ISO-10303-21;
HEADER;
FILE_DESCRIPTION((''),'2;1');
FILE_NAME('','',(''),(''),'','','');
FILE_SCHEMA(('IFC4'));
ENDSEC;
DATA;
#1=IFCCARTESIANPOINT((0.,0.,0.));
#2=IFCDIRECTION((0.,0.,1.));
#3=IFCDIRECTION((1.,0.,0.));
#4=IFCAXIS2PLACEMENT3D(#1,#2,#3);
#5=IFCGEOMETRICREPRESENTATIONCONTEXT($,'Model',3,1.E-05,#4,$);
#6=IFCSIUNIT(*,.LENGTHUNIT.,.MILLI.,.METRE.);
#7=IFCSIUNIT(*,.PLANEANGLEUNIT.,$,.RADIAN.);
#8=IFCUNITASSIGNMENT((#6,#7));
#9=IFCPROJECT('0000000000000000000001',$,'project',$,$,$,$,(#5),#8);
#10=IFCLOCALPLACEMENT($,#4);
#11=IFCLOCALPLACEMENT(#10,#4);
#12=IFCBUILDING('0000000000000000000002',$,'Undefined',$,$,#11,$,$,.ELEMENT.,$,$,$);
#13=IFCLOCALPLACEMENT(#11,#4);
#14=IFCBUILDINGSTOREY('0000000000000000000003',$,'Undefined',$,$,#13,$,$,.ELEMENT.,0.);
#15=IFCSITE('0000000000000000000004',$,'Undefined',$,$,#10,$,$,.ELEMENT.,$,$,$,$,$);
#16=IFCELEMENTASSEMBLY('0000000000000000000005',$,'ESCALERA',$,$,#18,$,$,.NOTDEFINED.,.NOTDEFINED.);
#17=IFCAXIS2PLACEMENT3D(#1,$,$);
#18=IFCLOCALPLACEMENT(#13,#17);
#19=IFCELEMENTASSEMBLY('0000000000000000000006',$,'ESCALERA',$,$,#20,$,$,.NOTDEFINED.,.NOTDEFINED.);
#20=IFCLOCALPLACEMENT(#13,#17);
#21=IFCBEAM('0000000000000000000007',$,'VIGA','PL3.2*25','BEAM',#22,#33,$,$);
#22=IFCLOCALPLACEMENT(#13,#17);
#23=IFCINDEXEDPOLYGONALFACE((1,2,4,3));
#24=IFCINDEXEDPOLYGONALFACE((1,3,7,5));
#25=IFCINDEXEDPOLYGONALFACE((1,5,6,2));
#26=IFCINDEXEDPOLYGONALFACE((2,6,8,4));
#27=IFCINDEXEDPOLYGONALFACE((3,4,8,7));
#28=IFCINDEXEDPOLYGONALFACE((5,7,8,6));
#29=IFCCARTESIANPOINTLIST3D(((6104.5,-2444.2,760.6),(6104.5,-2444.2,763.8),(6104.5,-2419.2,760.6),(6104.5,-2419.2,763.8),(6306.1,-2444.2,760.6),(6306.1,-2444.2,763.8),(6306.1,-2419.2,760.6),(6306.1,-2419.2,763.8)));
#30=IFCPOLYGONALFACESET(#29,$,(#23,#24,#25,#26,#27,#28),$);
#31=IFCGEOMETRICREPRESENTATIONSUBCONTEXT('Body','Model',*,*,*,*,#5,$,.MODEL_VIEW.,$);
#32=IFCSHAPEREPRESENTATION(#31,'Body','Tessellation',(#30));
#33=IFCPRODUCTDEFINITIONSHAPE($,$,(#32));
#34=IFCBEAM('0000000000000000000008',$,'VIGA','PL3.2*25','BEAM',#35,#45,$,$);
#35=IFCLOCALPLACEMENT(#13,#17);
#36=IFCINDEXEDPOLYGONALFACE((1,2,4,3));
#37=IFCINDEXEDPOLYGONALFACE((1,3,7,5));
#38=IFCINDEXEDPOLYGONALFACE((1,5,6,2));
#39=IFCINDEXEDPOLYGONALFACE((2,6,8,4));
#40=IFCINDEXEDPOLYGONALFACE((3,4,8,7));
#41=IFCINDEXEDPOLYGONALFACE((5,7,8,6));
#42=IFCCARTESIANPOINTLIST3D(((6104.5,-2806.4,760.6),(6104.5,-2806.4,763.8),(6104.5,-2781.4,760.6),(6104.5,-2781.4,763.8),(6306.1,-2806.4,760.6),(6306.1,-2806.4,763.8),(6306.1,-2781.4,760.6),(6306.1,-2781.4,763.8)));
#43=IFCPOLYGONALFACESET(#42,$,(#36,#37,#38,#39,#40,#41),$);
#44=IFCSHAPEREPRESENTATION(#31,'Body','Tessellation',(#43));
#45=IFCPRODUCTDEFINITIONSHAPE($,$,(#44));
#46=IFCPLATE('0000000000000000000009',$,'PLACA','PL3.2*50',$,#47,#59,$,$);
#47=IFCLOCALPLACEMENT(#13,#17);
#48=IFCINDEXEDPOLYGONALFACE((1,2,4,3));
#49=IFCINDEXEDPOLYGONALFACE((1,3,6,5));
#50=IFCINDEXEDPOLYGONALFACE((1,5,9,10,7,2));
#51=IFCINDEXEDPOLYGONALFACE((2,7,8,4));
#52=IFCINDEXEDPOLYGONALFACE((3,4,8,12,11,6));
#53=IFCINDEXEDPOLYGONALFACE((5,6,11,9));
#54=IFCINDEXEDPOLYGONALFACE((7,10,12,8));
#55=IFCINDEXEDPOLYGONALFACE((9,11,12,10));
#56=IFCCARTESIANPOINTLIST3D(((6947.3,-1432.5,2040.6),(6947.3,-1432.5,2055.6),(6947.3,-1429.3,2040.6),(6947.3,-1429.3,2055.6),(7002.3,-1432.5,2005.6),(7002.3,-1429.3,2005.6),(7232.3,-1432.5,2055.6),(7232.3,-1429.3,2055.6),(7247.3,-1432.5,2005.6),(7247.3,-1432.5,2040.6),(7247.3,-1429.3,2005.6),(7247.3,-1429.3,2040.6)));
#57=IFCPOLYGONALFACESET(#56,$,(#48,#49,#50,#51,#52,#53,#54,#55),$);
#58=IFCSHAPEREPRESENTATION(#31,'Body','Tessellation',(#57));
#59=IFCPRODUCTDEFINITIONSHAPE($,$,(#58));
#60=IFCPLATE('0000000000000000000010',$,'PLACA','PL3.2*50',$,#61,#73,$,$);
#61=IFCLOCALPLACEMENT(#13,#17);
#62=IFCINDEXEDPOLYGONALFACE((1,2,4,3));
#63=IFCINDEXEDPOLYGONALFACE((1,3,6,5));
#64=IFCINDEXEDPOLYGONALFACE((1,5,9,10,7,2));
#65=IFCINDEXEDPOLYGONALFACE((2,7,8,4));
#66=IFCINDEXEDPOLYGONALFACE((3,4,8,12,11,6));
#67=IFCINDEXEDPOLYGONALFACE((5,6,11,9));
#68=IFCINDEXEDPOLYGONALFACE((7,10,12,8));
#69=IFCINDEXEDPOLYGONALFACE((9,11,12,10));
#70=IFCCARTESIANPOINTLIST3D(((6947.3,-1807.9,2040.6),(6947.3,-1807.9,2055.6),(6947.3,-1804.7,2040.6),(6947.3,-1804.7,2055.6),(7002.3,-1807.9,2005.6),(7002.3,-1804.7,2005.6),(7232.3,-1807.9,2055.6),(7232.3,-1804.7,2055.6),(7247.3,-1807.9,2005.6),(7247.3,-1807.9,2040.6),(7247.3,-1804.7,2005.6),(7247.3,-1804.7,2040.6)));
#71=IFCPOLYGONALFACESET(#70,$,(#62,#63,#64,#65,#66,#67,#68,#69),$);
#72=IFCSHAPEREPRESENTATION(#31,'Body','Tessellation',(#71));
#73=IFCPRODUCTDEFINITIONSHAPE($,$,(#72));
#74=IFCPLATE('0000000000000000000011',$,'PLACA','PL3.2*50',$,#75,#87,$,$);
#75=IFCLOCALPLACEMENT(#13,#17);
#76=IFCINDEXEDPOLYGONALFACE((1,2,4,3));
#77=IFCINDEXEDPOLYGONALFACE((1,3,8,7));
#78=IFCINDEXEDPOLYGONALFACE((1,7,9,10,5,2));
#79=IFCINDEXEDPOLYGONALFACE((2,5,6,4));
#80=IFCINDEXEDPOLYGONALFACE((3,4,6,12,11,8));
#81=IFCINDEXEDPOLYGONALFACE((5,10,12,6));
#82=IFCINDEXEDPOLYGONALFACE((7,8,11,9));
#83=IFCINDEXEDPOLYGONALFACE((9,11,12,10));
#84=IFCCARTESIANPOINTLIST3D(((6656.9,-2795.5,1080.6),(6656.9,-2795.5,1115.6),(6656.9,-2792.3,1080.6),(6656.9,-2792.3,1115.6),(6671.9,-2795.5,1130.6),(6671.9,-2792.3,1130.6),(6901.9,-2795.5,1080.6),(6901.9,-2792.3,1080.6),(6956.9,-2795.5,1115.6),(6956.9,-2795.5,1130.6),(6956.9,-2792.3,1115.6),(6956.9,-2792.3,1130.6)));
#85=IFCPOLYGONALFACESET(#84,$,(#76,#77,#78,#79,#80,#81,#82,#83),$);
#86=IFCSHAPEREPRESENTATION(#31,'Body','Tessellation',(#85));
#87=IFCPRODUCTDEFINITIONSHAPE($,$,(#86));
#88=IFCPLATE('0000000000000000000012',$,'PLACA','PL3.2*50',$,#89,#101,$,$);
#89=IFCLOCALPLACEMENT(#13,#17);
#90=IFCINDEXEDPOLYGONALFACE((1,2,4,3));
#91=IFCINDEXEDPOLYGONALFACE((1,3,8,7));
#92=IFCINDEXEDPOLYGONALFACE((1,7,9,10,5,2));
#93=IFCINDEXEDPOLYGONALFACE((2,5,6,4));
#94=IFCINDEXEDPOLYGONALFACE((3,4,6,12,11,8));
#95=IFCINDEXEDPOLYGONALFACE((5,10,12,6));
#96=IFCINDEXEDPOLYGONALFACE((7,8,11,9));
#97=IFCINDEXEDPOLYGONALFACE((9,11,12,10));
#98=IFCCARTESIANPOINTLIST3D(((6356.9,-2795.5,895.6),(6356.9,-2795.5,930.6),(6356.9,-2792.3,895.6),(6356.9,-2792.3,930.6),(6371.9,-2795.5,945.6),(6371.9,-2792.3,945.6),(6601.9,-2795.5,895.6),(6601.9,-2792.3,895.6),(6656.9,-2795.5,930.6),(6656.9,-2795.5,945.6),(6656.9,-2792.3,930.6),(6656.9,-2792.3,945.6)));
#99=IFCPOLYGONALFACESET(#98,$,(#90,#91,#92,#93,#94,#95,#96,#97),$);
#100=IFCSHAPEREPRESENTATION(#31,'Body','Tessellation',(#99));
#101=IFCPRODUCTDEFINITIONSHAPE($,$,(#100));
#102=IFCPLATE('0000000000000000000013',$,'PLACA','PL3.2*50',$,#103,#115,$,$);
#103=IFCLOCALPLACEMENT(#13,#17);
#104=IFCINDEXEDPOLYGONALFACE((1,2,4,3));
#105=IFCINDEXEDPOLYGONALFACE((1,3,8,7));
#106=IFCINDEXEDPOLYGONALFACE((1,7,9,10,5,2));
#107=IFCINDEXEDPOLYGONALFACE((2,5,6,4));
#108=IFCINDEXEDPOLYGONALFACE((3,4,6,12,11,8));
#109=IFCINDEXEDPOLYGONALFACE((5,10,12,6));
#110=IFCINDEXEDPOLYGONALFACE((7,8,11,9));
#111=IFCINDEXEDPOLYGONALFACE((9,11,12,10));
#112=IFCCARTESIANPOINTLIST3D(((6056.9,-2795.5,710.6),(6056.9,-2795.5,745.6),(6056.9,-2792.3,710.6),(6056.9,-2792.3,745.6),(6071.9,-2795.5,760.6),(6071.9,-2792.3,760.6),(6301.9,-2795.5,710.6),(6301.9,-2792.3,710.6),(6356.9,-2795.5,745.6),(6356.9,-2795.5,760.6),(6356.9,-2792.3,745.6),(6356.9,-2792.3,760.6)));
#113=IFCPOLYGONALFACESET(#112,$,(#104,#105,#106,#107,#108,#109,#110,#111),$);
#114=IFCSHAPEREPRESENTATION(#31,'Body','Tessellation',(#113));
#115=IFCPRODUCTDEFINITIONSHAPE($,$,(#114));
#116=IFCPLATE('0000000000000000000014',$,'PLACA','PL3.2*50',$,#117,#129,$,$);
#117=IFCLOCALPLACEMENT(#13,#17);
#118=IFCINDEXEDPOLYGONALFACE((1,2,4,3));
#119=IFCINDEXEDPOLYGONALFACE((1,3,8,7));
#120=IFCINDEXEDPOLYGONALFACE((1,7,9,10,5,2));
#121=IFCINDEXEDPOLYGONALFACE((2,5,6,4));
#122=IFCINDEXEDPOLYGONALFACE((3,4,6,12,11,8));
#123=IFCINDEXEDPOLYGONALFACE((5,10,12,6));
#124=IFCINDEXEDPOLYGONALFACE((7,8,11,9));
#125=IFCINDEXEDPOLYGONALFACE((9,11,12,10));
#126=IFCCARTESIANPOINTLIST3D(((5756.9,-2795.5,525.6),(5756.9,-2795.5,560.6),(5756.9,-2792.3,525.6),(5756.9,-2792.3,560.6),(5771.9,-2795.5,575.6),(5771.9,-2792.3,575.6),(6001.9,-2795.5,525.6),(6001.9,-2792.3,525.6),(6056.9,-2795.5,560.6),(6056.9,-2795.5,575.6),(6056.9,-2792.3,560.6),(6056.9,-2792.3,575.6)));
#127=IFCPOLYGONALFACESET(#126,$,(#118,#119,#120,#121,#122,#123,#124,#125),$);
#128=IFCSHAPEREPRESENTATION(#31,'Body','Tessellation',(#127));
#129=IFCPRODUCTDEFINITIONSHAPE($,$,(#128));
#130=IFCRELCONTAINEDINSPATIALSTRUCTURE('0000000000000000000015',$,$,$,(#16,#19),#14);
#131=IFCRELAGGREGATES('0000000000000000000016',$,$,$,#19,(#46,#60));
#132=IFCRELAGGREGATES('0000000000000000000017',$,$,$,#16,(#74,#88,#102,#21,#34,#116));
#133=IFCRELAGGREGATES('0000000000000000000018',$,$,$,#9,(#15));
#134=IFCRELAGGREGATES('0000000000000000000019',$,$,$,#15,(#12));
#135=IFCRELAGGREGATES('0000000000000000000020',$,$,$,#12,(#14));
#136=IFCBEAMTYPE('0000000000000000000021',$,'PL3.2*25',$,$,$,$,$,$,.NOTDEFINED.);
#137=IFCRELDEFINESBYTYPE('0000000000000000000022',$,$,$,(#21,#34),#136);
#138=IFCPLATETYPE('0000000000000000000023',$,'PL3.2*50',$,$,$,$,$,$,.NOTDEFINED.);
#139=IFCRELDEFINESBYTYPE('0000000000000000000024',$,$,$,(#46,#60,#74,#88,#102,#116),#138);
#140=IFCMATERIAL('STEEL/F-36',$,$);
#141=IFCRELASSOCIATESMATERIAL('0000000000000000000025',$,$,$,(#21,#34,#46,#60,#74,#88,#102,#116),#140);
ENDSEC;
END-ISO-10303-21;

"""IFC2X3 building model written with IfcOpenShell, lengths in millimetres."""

from ifc_helpers import new_model, si_unit, frame, origin_with_axes, origin_2d_with_axis, place, context, subcontext, project, spatial, polyline, rectangle, outline, extrude, material, type_object, element, aggregate, save


model = new_model("IFC2X3")

# Units and contexts
model_context = context("Model", 3, precision=1e-05, world=origin_with_axes())
body_context = subcontext(model_context, "Body", "Model", "MODEL_VIEW")
ifc_project = project(units=[si_unit("LENGTHUNIT", "METRE", prefix="MILLI"), si_unit("PLANEANGLEUNIT", "RADIAN")], contexts=[model_context])

# Site, building, storey
site_placement = place(None, origin_with_axes())
site = spatial("IfcSite", under=ifc_project, at=site_placement, Name="Undefined", CompositionType="ELEMENT")
building_placement = place(site_placement, origin_with_axes())
building = spatial("IfcBuilding", under=site, at=building_placement, Name="Undefined", CompositionType="ELEMENT")
storey_placement = place(building_placement, origin_with_axes())
storey = spatial("IfcBuildingStorey", under=building, at=storey_placement, Name="Undefined", CompositionType="ELEMENT", Elevation=0.0)

# Element assembly
assembly_1_placement = place(storey_placement, origin_with_axes())
assembly_1 = element("IfcElementAssembly", 1, at=assembly_1_placement, inside=storey, Name="ESCALERA", AssemblyPlace="NOTDEFINED", PredefinedType="NOTDEFINED")
ifc_material_1 = material(Name="STEEL/F-36")

# Element assembly
assembly_2_placement = place(storey_placement, origin_with_axes())
assembly_2 = element("IfcElementAssembly", 2, at=assembly_2_placement, inside=storey, Name="ESCALERA", AssemblyPlace="NOTDEFINED", PredefinedType="NOTDEFINED")
beam_type_1 = type_object("IfcBeamType", Name="PL3.2*25", PredefinedType="NOTDEFINED")

# Beams
beam_1_placement = place(assembly_1_placement, frame((6104.5, -2431.7, 762.2), z_axis=(0.0, 1.0, 0.0), x_axis=(1.0, 0.0, 0.000012)))
beam_1 = element("IfcBeam", 3, at=beam_1_placement, type_object=beam_type_1, material=ifc_material_1, Name="VIGA", Description="PL3.2*25", ObjectType="BEAM", context=body_context, shape_type="SweptSolid", body=[
    extrude(rectangle(XDim=3.2, YDim=25.0, at=origin_2d_with_axis()), frame((201.6, 0.0, 0.0), z_axis=(-1.0, 0.0, 0.0), x_axis=(0.0, -1.0, 0.0)), (0.0, 0.0, 1.0), 201.6),
])
beam_2_placement = place(assembly_1_placement, frame((6104.5, -2793.9, 762.2), z_axis=(0.0, 1.0, 0.0), x_axis=(1.0, 0.0, 0.000012)))
beam_2 = element("IfcBeam", 4, at=beam_2_placement, type_object=beam_type_1, material=ifc_material_1, Name="VIGA", Description="PL3.2*25", ObjectType="BEAM", context=body_context, shape_type="SweptSolid", body=[
    extrude(rectangle(XDim=3.2, YDim=25.0, at=origin_2d_with_axis()), frame((201.6, 0.0, 0.0), z_axis=(-1.0, 0.0, 0.0), x_axis=(0.0, -1.0, 0.0)), (0.0, 0.0, 1.0), 201.6),
])

# Plates
plate_type = type_object("IfcPlateType", Name="PL3.2*50", PredefinedType="NOTDEFINED")
plate_1_placement = place(assembly_2_placement, frame((6947.3, -1430.9, 2055.6), z_axis=(0.0, -1.0, 0.0), x_axis=(0.0, 0.0, -1.0)))
plate_1 = element("IfcPlate", 5, at=plate_1_placement, type_object=plate_type, material=ifc_material_1, Name="PLACA", Description="PL3.2*50", context=body_context, shape_type="SweptSolid", body=[
    extrude(outline(polyline([(0.0, 0.0), (15.0, 0.0), (50.0, 55.0), (50.0, 300.0), (50.0, 300.0), (15.0, 300.0), (0.0, 285.0), (0.0, 0.0)])), frame((0.0, 0.0, -1.6), z_axis=(0.0, 0.0, 1.0), x_axis=(1.0, 0.0, 0.0)), (0.0, 0.0, 1.0), 3.2),
])
plate_2_placement = place(assembly_2_placement, frame((6947.3, -1806.3, 2055.6), z_axis=(0.0, -1.0, 0.0), x_axis=(0.0, 0.0, -1.0)))
plate_2 = element("IfcPlate", 6, at=plate_2_placement, type_object=plate_type, material=ifc_material_1, Name="PLACA", Description="PL3.2*50", context=body_context, shape_type="SweptSolid", body=[
    extrude(outline(polyline([(0.0, 0.0), (15.0, 0.0), (50.0, 55.0), (50.0, 300.0), (50.0, 300.0), (15.0, 300.0), (0.0, 285.0), (0.0, 0.0)])), frame((0.0, 0.0, -1.6), z_axis=(0.0, 0.0, 1.0), x_axis=(1.0, 0.0, 0.0)), (0.0, 0.0, 1.0), 3.2),
])
aggregate(assembly_2, [plate_1, plate_2])
plate_3_placement = place(assembly_1_placement, frame((6956.9, -2793.9, 1130.6), z_axis=(0.0, 1.0, 0.0), x_axis=(0.0, 0.0, -1.0)))
plate_3 = element("IfcPlate", 7, at=plate_3_placement, type_object=plate_type, material=ifc_material_1, Name="PLACA", Description="PL3.2*50", context=body_context, shape_type="SweptSolid", body=[
    extrude(outline(polyline([(0.0, 0.0), (15.0, 0.0), (50.0, 55.0), (50.0, 300.0), (50.0, 300.0), (15.0, 300.0), (0.0, 285.0), (0.0, 0.0)])), frame((0.0, 0.0, -1.6), z_axis=(0.0, 0.0, 1.0), x_axis=(1.0, 0.0, 0.0)), (0.0, 0.0, 1.0), 3.2),
])
plate_4_placement = place(assembly_1_placement, frame((6656.9, -2793.9, 945.6), z_axis=(0.0, 1.0, 0.0), x_axis=(0.0, 0.0, -1.0)))
plate_4 = element("IfcPlate", 8, at=plate_4_placement, type_object=plate_type, material=ifc_material_1, Name="PLACA", Description="PL3.2*50", context=body_context, shape_type="SweptSolid", body=[
    extrude(outline(polyline([(0.0, 0.0), (15.0, 0.0), (50.0, 55.0), (50.0, 300.0), (50.0, 300.0), (15.0, 300.0), (0.0, 285.0), (0.0, 0.0)])), frame((0.0, 0.0, -1.6), z_axis=(0.0, 0.0, 1.0), x_axis=(1.0, 0.0, 0.0)), (0.0, 0.0, 1.0), 3.2),
])
plate_5_placement = place(assembly_1_placement, frame((6356.9, -2793.9, 760.6), z_axis=(0.0, 1.0, 0.0), x_axis=(0.0, 0.0, -1.0)))
plate_5 = element("IfcPlate", 9, at=plate_5_placement, type_object=plate_type, material=ifc_material_1, Name="PLACA", Description="PL3.2*50", context=body_context, shape_type="SweptSolid", body=[
    extrude(outline(polyline([(0.0, 0.0), (15.0, 0.0), (50.0, 55.0), (50.0, 300.0), (50.0, 300.0), (15.0, 300.0), (0.0, 285.0), (0.0, 0.0)])), frame((0.0, 0.0, -1.6), z_axis=(0.0, 0.0, 1.0), x_axis=(1.0, 0.0, 0.0)), (0.0, 0.0, 1.0), 3.2),
])
plate_6_placement = place(assembly_1_placement, frame((6056.9, -2793.9, 575.6), z_axis=(0.0, 1.0, 0.0), x_axis=(0.0, 0.0, -1.0)))
plate_6 = element("IfcPlate", 10, at=plate_6_placement, type_object=plate_type, material=ifc_material_1, Name="PLACA", Description="PL3.2*50", context=body_context, shape_type="SweptSolid", body=[
    extrude(outline(polyline([(0.0, 0.0), (15.0, 0.0), (50.0, 55.0), (50.0, 300.0), (50.0, 300.0), (15.0, 300.0), (0.0, 285.0), (0.0, 0.0)])), frame((0.0, 0.0, -1.6), z_axis=(0.0, 0.0, 1.0), x_axis=(1.0, 0.0, 0.0)), (0.0, 0.0, 1.0), 3.2),
])
aggregate(assembly_1, [plate_3, plate_4, plate_5, beam_1, beam_2, plate_6])

save(model, "model.ifc")
